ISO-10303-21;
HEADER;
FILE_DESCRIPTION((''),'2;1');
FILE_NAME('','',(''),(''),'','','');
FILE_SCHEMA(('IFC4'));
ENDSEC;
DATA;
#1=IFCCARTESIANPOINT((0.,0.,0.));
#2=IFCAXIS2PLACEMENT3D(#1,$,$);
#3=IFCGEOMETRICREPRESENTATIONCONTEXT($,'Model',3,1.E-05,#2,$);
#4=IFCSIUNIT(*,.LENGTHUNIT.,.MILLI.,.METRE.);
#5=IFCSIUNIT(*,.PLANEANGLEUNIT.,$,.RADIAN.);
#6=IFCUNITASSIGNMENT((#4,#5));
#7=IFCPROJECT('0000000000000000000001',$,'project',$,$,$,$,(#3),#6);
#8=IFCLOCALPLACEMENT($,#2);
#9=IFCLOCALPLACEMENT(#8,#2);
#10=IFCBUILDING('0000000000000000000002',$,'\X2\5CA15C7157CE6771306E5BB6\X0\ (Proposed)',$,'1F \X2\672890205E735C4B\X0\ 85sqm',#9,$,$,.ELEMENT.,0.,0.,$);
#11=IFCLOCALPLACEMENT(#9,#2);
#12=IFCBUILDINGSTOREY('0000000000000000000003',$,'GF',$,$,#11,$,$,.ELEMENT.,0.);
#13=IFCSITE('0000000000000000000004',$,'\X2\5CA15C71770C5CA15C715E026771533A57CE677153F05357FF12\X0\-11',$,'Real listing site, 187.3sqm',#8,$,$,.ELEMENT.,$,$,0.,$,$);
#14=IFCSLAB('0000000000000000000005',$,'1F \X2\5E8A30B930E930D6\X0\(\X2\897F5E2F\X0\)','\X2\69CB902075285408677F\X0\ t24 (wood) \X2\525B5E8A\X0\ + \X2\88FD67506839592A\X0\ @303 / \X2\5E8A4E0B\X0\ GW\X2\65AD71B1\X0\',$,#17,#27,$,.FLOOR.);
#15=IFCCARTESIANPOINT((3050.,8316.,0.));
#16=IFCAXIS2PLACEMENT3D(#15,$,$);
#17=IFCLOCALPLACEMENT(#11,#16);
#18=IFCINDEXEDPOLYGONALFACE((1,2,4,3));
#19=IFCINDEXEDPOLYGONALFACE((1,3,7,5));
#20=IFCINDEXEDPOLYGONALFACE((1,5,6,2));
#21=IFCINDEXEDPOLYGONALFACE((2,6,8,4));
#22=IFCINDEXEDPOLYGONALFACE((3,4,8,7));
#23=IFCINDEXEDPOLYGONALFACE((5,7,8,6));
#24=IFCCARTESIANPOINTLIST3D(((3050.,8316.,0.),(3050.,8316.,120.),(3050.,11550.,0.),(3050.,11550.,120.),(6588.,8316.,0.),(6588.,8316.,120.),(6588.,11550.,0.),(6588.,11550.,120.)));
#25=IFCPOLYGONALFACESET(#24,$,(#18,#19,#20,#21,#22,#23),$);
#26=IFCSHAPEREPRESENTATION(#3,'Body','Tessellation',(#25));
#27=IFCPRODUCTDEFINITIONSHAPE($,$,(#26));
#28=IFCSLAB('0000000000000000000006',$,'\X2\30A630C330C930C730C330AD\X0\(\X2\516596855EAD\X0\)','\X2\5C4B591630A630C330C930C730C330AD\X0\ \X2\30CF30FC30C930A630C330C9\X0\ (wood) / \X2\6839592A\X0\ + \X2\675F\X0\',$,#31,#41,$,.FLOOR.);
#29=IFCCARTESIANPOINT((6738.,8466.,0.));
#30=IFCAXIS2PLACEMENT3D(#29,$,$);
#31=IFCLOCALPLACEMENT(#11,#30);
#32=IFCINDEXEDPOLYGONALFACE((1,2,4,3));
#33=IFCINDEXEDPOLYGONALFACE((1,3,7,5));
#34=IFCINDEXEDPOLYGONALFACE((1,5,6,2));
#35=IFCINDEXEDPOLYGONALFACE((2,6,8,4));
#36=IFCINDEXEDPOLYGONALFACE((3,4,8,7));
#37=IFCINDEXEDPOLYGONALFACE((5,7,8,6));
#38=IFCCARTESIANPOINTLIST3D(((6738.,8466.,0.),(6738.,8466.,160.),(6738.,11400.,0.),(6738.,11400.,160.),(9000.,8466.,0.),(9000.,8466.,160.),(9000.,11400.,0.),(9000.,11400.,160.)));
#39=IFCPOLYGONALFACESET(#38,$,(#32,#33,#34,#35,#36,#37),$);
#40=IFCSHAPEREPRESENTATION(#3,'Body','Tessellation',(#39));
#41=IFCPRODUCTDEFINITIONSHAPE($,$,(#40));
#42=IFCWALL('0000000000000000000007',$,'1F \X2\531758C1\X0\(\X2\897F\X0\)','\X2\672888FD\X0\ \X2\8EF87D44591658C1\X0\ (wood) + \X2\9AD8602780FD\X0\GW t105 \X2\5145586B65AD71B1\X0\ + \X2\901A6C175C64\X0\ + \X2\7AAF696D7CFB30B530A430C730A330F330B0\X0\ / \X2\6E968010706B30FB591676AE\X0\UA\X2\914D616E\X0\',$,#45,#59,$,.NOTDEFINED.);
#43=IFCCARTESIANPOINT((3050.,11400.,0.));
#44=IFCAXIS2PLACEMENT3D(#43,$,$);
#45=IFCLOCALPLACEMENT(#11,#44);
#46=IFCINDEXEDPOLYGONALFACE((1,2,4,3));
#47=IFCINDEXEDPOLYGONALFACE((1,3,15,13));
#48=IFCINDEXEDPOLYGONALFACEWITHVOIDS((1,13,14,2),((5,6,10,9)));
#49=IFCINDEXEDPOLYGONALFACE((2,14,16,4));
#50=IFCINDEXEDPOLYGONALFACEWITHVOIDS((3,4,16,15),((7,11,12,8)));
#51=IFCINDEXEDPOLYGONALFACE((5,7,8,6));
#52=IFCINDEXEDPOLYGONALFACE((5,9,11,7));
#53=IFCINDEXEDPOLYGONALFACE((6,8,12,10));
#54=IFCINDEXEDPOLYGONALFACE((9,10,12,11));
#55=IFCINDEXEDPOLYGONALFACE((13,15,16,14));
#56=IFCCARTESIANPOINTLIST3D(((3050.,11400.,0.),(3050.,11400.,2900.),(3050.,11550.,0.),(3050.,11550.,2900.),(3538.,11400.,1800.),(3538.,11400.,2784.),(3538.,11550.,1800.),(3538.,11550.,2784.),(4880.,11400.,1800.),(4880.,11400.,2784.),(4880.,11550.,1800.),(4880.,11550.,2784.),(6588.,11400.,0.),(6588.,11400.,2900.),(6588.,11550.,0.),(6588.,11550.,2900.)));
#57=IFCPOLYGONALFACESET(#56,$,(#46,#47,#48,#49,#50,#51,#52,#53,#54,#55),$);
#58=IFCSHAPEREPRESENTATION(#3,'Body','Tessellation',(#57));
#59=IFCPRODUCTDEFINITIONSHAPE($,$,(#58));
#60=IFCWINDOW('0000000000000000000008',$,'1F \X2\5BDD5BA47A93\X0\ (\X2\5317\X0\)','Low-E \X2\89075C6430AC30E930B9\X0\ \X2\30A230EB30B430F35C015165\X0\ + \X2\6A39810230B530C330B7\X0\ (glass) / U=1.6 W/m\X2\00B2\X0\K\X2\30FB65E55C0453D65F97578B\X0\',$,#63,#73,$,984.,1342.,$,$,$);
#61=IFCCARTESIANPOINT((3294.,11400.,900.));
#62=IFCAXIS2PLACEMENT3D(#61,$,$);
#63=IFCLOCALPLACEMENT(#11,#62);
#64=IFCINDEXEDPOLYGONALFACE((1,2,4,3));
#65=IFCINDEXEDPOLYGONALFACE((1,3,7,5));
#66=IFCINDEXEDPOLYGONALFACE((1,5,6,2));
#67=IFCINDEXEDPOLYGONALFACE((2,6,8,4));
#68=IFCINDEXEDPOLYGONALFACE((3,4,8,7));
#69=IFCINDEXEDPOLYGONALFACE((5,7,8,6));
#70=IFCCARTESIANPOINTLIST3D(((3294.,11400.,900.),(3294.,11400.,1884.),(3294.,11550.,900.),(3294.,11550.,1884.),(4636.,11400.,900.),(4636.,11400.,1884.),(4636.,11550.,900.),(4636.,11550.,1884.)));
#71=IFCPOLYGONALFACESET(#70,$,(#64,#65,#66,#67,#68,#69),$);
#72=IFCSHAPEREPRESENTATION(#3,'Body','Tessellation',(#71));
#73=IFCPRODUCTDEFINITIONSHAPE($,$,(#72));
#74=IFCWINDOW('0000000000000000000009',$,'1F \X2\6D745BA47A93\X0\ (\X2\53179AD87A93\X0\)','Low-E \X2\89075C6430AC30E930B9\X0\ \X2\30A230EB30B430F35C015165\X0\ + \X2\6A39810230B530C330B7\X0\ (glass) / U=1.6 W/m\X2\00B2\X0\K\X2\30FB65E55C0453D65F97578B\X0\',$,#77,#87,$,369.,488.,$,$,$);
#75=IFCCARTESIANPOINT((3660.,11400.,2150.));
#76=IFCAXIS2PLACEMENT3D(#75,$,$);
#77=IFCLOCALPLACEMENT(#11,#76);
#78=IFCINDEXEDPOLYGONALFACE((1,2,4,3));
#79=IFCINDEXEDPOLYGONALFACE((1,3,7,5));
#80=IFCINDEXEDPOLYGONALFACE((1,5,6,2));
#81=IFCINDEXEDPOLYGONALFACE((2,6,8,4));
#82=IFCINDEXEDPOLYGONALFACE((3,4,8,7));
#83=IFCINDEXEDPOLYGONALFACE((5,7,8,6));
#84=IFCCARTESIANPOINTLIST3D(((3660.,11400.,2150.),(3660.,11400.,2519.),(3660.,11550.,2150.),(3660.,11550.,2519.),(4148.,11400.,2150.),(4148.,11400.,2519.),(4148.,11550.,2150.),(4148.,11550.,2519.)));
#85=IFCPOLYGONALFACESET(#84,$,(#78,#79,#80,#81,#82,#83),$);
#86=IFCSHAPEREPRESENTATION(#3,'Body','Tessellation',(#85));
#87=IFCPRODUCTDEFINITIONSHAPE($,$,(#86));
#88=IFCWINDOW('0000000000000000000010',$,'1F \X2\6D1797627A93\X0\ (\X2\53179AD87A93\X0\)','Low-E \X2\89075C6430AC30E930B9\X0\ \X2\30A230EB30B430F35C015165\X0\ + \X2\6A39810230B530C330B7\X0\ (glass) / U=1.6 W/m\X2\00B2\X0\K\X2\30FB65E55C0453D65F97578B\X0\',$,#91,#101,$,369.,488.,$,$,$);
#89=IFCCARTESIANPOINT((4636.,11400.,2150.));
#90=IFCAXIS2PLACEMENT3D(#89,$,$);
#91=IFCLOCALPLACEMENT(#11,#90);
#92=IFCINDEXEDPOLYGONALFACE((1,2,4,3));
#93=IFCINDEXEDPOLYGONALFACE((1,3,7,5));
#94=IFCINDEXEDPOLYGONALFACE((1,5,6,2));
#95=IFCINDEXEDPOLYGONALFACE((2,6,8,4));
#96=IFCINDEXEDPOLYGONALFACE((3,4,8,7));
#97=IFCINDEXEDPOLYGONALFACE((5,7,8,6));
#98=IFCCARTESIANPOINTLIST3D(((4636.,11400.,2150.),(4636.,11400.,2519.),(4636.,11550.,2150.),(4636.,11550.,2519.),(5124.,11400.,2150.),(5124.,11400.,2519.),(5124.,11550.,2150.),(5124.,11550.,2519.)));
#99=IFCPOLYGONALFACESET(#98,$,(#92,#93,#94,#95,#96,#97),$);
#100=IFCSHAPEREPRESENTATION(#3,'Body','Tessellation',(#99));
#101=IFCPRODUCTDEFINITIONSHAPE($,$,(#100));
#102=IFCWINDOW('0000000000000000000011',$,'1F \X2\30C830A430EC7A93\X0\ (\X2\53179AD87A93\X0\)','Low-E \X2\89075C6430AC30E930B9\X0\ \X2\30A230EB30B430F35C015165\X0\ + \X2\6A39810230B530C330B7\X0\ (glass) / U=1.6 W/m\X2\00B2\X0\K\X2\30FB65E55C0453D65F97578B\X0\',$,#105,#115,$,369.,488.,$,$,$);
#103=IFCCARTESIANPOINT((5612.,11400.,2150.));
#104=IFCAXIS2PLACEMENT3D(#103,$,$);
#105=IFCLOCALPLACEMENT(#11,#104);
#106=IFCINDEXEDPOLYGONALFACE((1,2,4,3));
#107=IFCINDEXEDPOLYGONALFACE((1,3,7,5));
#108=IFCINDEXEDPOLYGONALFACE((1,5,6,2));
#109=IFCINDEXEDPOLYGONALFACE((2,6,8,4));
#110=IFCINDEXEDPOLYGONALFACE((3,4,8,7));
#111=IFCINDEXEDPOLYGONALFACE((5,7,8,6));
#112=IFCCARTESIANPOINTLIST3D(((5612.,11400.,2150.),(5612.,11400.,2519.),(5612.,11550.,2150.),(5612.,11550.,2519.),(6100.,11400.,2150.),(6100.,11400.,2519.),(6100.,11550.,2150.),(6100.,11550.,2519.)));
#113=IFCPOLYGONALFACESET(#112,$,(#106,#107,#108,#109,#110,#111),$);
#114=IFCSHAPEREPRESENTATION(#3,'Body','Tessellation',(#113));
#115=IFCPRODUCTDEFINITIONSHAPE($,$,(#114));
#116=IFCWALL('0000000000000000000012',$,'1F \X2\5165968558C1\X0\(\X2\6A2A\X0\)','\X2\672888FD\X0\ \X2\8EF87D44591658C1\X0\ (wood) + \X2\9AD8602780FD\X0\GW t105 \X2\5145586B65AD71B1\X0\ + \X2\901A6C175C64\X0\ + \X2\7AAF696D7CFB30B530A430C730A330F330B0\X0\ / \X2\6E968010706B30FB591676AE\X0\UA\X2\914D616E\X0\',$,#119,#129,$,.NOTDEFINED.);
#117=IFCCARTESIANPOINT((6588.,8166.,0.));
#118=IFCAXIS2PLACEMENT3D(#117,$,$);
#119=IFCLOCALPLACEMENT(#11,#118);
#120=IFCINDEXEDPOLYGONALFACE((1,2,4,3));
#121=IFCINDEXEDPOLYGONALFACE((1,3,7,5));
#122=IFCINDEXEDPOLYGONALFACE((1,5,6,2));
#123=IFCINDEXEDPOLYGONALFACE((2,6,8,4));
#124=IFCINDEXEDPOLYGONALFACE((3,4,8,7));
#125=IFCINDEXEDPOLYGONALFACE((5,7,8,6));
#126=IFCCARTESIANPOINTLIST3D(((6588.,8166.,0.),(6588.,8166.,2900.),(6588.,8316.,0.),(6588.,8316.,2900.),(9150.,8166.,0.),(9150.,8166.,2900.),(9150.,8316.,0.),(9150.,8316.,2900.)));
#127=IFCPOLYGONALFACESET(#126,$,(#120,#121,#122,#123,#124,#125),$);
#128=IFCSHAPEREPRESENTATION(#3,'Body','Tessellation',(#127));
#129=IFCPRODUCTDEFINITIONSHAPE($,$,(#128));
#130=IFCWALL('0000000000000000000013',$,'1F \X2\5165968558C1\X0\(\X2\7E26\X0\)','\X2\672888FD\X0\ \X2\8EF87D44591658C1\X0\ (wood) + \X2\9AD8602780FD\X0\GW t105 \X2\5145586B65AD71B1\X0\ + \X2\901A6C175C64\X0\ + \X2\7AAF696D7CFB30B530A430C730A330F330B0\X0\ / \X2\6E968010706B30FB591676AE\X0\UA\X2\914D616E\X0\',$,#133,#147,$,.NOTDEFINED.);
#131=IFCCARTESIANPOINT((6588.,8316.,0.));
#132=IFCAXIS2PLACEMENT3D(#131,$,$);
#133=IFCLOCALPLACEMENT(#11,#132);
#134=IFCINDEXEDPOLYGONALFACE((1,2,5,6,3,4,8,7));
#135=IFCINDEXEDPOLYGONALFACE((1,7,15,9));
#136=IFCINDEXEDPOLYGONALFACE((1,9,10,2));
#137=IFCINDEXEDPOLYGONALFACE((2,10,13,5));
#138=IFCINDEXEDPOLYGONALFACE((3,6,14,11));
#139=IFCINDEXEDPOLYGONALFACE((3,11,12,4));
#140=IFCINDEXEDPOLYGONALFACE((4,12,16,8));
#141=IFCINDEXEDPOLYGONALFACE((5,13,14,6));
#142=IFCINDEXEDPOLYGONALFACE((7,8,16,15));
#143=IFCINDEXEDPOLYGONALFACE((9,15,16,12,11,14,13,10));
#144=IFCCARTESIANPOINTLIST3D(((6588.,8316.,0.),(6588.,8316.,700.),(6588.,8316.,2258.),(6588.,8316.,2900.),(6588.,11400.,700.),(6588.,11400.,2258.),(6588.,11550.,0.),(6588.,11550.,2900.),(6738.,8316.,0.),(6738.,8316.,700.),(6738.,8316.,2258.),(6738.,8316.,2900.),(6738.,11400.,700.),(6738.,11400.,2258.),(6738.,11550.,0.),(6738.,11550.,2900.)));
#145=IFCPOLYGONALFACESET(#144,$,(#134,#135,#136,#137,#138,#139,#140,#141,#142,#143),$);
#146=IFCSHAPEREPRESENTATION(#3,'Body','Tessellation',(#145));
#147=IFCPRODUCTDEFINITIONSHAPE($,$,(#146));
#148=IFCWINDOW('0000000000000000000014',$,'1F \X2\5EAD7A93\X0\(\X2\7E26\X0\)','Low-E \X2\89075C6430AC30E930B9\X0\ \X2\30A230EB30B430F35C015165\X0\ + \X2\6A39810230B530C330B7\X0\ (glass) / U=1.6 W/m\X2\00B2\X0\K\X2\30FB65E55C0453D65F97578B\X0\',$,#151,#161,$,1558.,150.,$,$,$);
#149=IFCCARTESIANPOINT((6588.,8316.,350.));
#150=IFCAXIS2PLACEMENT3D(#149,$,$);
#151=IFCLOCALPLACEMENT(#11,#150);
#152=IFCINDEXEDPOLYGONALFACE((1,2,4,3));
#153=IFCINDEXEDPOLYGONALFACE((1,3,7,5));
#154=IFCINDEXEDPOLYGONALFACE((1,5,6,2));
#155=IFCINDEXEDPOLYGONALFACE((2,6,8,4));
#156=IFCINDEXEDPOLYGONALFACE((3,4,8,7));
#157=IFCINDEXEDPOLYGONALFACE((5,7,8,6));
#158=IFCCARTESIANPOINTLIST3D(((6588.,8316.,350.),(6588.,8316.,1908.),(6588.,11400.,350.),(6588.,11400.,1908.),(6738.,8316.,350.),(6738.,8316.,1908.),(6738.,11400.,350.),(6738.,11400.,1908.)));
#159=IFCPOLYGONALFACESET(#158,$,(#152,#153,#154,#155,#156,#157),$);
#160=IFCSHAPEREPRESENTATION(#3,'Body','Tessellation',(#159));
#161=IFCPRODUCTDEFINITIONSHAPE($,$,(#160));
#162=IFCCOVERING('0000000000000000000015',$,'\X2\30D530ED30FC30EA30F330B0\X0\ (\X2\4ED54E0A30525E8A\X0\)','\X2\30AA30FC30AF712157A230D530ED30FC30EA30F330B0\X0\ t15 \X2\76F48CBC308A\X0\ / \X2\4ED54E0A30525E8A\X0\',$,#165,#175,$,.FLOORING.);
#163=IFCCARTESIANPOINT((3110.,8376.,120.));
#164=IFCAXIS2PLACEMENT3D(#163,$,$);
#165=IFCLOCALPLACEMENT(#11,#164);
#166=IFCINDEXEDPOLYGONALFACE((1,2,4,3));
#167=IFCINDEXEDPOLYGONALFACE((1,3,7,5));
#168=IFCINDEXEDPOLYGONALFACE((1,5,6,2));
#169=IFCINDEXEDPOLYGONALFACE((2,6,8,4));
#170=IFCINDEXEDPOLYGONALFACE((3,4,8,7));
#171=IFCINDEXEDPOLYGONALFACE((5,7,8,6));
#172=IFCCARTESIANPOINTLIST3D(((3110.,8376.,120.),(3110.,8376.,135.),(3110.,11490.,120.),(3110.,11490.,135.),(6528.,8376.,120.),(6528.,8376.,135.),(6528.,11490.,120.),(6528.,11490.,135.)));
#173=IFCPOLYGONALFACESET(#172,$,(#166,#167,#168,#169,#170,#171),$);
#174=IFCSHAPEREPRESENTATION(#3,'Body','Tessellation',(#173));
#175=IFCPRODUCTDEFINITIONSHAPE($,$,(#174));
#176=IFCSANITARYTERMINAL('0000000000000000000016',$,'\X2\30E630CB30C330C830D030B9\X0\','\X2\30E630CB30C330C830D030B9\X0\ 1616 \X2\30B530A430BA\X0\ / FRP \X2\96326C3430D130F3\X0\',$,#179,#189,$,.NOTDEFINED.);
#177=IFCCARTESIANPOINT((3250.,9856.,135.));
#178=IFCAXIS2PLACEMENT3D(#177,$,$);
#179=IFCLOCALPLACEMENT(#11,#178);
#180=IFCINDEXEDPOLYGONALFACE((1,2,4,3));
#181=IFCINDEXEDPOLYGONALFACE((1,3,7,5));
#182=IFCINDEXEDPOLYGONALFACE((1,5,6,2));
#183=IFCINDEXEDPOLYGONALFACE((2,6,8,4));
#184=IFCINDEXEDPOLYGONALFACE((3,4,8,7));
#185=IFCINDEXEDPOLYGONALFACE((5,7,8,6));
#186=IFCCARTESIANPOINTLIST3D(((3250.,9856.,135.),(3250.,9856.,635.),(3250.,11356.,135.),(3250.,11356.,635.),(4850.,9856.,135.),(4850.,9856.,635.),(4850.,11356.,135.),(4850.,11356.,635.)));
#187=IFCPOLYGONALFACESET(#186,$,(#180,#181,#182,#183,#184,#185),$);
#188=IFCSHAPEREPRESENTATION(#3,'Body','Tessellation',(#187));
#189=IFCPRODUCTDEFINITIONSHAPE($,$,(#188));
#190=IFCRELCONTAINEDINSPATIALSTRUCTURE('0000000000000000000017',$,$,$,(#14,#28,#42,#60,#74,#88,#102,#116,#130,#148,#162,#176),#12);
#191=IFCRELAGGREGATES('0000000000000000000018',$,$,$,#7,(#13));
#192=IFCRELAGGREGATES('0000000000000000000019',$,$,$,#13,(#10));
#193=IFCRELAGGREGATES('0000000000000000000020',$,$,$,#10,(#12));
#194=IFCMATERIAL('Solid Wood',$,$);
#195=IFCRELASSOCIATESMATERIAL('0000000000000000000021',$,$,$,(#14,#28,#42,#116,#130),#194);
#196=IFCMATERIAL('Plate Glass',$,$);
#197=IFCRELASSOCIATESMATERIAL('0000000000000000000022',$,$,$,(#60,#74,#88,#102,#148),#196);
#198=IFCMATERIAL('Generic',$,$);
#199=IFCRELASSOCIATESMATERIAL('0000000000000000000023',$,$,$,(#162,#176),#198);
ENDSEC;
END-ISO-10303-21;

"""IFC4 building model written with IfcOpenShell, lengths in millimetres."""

from ifc_helpers import new_model, si_unit, frame, frame_2d, origin, place, context, project, spatial, rectangle, extrude, material, element, fill, save


model = new_model("IFC4")

# Units and contexts
model_context = context("Model", 3, precision=1e-05, world=origin())
ifc_project = project(units=[si_unit("LENGTHUNIT", "METRE", prefix="MILLI"), si_unit("PLANEANGLEUNIT", "RADIAN")], contexts=[model_context])

# Site, building, storey
site_placement = place(None, origin())
site = spatial("IfcSite", under=ifc_project, at=site_placement, Name="岡山県岡山市東区城東台南２-11", ObjectType="Real listing site, 187.3sqm", CompositionType="ELEMENT", RefElevation=0.0)
building_placement = place(site_placement, origin())
building = spatial("IfcBuilding", under=site, at=building_placement, Name="岡山城東の家 (Proposed)", ObjectType="1F 木造平屋 85sqm", CompositionType="ELEMENT", ElevationOfRefHeight=0.0, ElevationOfTerrain=0.0)
storey_placement = place(building_placement, origin())
storey = spatial("IfcBuildingStorey", under=building, at=storey_placement, Name="GF", CompositionType="ELEMENT", Elevation=0.0)

# Slabs
ifc_material_1 = material(Name="Solid Wood")
slab_1_placement = place(storey_placement, frame((3050.0, 8316.0, 0.0)))
element("IfcSlab", 1, at=slab_1_placement, inside=storey, material=ifc_material_1, Name="1F 床スラブ(西帯)", Description="構造用合板 t24 (wood) 剛床 + 製材根太 @303 / 床下 GW断熱", PredefinedType="FLOOR", context=model_context, shape_type="SweptSolid", body=[
    extrude(rectangle(XDim=3538.0, YDim=3234.0, at=frame_2d((1769.0, 1617.0))), frame((3050.0, 8316.0, 0.0)), (0.0, 0.0, 1.0), 120.0),
])
slab_2_placement = place(storey_placement, frame((6738.0, 8466.0, 0.0)))
element("IfcSlab", 2, at=slab_2_placement, inside=storey, material=ifc_material_1, Name="ウッドデッキ(入隅庭)", Description="屋外ウッドデッキ ハードウッド (wood) / 根太 + 束", PredefinedType="FLOOR", context=model_context, shape_type="SweptSolid", body=[
    extrude(rectangle(XDim=2262.0, YDim=2934.0, at=frame_2d((1131.0, 1467.0))), frame((6738.0, 8466.0, 0.0)), (0.0, 0.0, 1.0), 160.0),
])

# Wall, openings, windows
wall_1_placement = place(storey_placement, frame((3050.0, 11400.0, 0.0)))
wall_1 = element("IfcWall", 3, at=wall_1_placement, inside=storey, material=ifc_material_1, Name="1F 北壁(西)", Description="木製 軸組外壁 (wood) + 高性能GW t105 充填断熱 + 通気層 + 窯業系サイディング / 準耐火・外皮UA配慮", PredefinedType="NOTDEFINED", context=model_context, shape_type="SweptSolid", body=[
    extrude(rectangle(XDim=3538.0, YDim=150.0, at=frame_2d((1769.0, 75.0))), frame((3050.0, 11400.0, 0.0)), (0.0, 0.0, 1.0), 2900.0),
])
opening_1_placement = place(storey_placement, frame((3294.0, 11400.0, 900.0)))
opening_1 = element("IfcOpeningElement", 4, at=opening_1_placement, cuts=wall_1, PredefinedType="NOTDEFINED", context=model_context, shape_type="SweptSolid", body=[
    extrude(rectangle(XDim=1342.0, YDim=150.0, at=frame_2d((671.0, 75.0))), frame((3294.0, 11400.0, 900.0)), (0.0, 0.0, 1.0), 984.0),
])
opening_2_placement = place(storey_placement, frame((3660.0, 11400.0, 2150.0)))
opening_2 = element("IfcOpeningElement", 5, at=opening_2_placement, cuts=wall_1, PredefinedType="NOTDEFINED", context=model_context, shape_type="SweptSolid", body=[
    extrude(rectangle(XDim=488.0, YDim=150.0, at=frame_2d((244.0, 75.0))), frame((3660.0, 11400.0, 2150.0)), (0.0, 0.0, 1.0), 369.0),
])
opening_3_placement = place(storey_placement, frame((4636.0, 11400.0, 2150.0)))
opening_3 = element("IfcOpeningElement", 6, at=opening_3_placement, cuts=wall_1, PredefinedType="NOTDEFINED", context=model_context, shape_type="SweptSolid", body=[
    extrude(rectangle(XDim=488.0, YDim=150.0, at=frame_2d((244.0, 75.0))), frame((4636.0, 11400.0, 2150.0)), (0.0, 0.0, 1.0), 369.0),
])
opening_4_placement = place(storey_placement, frame((5612.0, 11400.0, 2150.0)))
opening_4 = element("IfcOpeningElement", 7, at=opening_4_placement, cuts=wall_1, PredefinedType="NOTDEFINED", context=model_context, shape_type="SweptSolid", body=[
    extrude(rectangle(XDim=488.0, YDim=150.0, at=frame_2d((244.0, 75.0))), frame((5612.0, 11400.0, 2150.0)), (0.0, 0.0, 1.0), 369.0),
])
ifc_material_2 = material(Name="Plate Glass")
window_1_placement = place(storey_placement, frame((3294.0, 11400.0, 900.0)))
window_1 = element("IfcWindow", 8, at=window_1_placement, inside=storey, material=ifc_material_2, Name="1F 寝室窓 (北)", Description="Low-E 複層ガラス アルゴン封入 + 樹脂サッシ (glass) / U=1.6 W/m²K・日射取得型", OverallHeight=984.0, OverallWidth=1342.0, context=model_context, shape_type="SweptSolid", body=[
    extrude(rectangle(XDim=1342.0, YDim=150.0, at=frame_2d((671.0, 75.0))), frame((3294.0, 11400.0, 900.0)), (0.0, 0.0, 1.0), 984.0),
])
fill(opening_1, window_1)
window_2_placement = place(storey_placement, frame((3660.0, 11400.0, 2150.0)))
window_2 = element("IfcWindow", 9, at=window_2_placement, inside=storey, material=ifc_material_2, Name="1F 浴室窓 (北高窓)", Description="Low-E 複層ガラス アルゴン封入 + 樹脂サッシ (glass) / U=1.6 W/m²K・日射取得型", OverallHeight=369.0, OverallWidth=488.0, context=model_context, shape_type="SweptSolid", body=[
    extrude(rectangle(XDim=488.0, YDim=150.0, at=frame_2d((244.0, 75.0))), frame((3660.0, 11400.0, 2150.0)), (0.0, 0.0, 1.0), 369.0),
])
fill(opening_2, window_2)
window_3_placement = place(storey_placement, frame((4636.0, 11400.0, 2150.0)))
window_3 = element("IfcWindow", 10, at=window_3_placement, inside=storey, material=ifc_material_2, Name="1F 洗面窓 (北高窓)", Description="Low-E 複層ガラス アルゴン封入 + 樹脂サッシ (glass) / U=1.6 W/m²K・日射取得型", OverallHeight=369.0, OverallWidth=488.0, context=model_context, shape_type="SweptSolid", body=[
    extrude(rectangle(XDim=488.0, YDim=150.0, at=frame_2d((244.0, 75.0))), frame((4636.0, 11400.0, 2150.0)), (0.0, 0.0, 1.0), 369.0),
])
fill(opening_3, window_3)
window_4_placement = place(storey_placement, frame((5612.0, 11400.0, 2150.0)))
window_4 = element("IfcWindow", 11, at=window_4_placement, inside=storey, material=ifc_material_2, Name="1F トイレ窓 (北高窓)", Description="Low-E 複層ガラス アルゴン封入 + 樹脂サッシ (glass) / U=1.6 W/m²K・日射取得型", OverallHeight=369.0, OverallWidth=488.0, context=model_context, shape_type="SweptSolid", body=[
    extrude(rectangle(XDim=488.0, YDim=150.0, at=frame_2d((244.0, 75.0))), frame((5612.0, 11400.0, 2150.0)), (0.0, 0.0, 1.0), 369.0),
])
fill(opening_4, window_4)

# Wall
wall_2_placement = place(storey_placement, frame((6588.0, 8166.0, 0.0)))
element("IfcWall", 12, at=wall_2_placement, inside=storey, material=ifc_material_1, Name="1F 入隅壁(横)", Description="木製 軸組外壁 (wood) + 高性能GW t105 充填断熱 + 通気層 + 窯業系サイディング / 準耐火・外皮UA配慮", PredefinedType="NOTDEFINED", context=model_context, shape_type="SweptSolid", body=[
    extrude(rectangle(XDim=2562.0, YDim=150.0, at=frame_2d((1281.0, 75.0))), frame((6588.0, 8166.0, 0.0)), (0.0, 0.0, 1.0), 2900.0),
])

# Wall, opening, window
wall_3_placement = place(storey_placement, frame((6588.0, 8316.0, 0.0)))
wall_3 = element("IfcWall", 13, at=wall_3_placement, inside=storey, material=ifc_material_1, Name="1F 入隅壁(縦)", Description="木製 軸組外壁 (wood) + 高性能GW t105 充填断熱 + 通気層 + 窯業系サイディング / 準耐火・外皮UA配慮", PredefinedType="NOTDEFINED", context=model_context, shape_type="SweptSolid", body=[
    extrude(rectangle(XDim=150.0, YDim=3234.0, at=frame_2d((75.0, 1617.0))), frame((6588.0, 8316.0, 0.0)), (0.0, 0.0, 1.0), 2900.0),
])
opening_5_placement = place(storey_placement, frame((6588.0, 8316.0, 350.0)))
opening_5 = element("IfcOpeningElement", 14, at=opening_5_placement, cuts=wall_3, PredefinedType="NOTDEFINED", context=model_context, shape_type="SweptSolid", body=[
    extrude(rectangle(XDim=150.0, YDim=3084.0, at=frame_2d((75.0, 1542.0))), frame((6588.0, 8316.0, 350.0)), (0.0, 0.0, 1.0), 1558.0),
])
window_5_placement = place(storey_placement, frame((6588.0, 8316.0, 350.0)))
window_5 = element("IfcWindow", 15, at=window_5_placement, inside=storey, material=ifc_material_2, Name="1F 庭窓(縦)", Description="Low-E 複層ガラス アルゴン封入 + 樹脂サッシ (glass) / U=1.6 W/m²K・日射取得型", OverallHeight=1558.0, OverallWidth=150.0, context=model_context, shape_type="SweptSolid", body=[
    extrude(rectangle(XDim=150.0, YDim=3084.0, at=frame_2d((75.0, 1542.0))), frame((6588.0, 8316.0, 350.0)), (0.0, 0.0, 1.0), 1558.0),
])
fill(opening_5, window_5)

# Covering
ifc_material_3 = material(Name="Generic")
covering_placement = place(storey_placement, frame((3110.0, 8376.0, 120.0)))
element("IfcCovering", 16, at=covering_placement, inside=storey, material=ifc_material_3, Name="フローリング (仕上げ床)", Description="オーク無垢フローリング t15 直貼り / 仕上げ床", PredefinedType="FLOORING", context=model_context, shape_type="SweptSolid", body=[
    extrude(rectangle(XDim=3418.0, YDim=3114.0, at=frame_2d((1709.0, 1557.0))), frame((3110.0, 8376.0, 120.0)), (0.0, 0.0, 1.0), 15.0),
])

# Sanitary terminal
sanitary_terminal_1_placement = place(storey_placement, frame((3250.0, 9856.0, 135.0)))
element("IfcSanitaryTerminal", 17, at=sanitary_terminal_1_placement, inside=storey, material=ifc_material_3, Name="ユニットバス", Description="ユニットバス 1616 サイズ / FRP 防水パン", PredefinedType="NOTDEFINED", context=model_context, shape_type="SweptSolid", body=[
    extrude(rectangle(XDim=1600.0, YDim=1500.0, at=frame_2d((800.0, 750.0))), frame((3250.0, 9856.0, 135.0)), (0.0, 0.0, 1.0), 500.0),
])

save(model, "model.ifc")
